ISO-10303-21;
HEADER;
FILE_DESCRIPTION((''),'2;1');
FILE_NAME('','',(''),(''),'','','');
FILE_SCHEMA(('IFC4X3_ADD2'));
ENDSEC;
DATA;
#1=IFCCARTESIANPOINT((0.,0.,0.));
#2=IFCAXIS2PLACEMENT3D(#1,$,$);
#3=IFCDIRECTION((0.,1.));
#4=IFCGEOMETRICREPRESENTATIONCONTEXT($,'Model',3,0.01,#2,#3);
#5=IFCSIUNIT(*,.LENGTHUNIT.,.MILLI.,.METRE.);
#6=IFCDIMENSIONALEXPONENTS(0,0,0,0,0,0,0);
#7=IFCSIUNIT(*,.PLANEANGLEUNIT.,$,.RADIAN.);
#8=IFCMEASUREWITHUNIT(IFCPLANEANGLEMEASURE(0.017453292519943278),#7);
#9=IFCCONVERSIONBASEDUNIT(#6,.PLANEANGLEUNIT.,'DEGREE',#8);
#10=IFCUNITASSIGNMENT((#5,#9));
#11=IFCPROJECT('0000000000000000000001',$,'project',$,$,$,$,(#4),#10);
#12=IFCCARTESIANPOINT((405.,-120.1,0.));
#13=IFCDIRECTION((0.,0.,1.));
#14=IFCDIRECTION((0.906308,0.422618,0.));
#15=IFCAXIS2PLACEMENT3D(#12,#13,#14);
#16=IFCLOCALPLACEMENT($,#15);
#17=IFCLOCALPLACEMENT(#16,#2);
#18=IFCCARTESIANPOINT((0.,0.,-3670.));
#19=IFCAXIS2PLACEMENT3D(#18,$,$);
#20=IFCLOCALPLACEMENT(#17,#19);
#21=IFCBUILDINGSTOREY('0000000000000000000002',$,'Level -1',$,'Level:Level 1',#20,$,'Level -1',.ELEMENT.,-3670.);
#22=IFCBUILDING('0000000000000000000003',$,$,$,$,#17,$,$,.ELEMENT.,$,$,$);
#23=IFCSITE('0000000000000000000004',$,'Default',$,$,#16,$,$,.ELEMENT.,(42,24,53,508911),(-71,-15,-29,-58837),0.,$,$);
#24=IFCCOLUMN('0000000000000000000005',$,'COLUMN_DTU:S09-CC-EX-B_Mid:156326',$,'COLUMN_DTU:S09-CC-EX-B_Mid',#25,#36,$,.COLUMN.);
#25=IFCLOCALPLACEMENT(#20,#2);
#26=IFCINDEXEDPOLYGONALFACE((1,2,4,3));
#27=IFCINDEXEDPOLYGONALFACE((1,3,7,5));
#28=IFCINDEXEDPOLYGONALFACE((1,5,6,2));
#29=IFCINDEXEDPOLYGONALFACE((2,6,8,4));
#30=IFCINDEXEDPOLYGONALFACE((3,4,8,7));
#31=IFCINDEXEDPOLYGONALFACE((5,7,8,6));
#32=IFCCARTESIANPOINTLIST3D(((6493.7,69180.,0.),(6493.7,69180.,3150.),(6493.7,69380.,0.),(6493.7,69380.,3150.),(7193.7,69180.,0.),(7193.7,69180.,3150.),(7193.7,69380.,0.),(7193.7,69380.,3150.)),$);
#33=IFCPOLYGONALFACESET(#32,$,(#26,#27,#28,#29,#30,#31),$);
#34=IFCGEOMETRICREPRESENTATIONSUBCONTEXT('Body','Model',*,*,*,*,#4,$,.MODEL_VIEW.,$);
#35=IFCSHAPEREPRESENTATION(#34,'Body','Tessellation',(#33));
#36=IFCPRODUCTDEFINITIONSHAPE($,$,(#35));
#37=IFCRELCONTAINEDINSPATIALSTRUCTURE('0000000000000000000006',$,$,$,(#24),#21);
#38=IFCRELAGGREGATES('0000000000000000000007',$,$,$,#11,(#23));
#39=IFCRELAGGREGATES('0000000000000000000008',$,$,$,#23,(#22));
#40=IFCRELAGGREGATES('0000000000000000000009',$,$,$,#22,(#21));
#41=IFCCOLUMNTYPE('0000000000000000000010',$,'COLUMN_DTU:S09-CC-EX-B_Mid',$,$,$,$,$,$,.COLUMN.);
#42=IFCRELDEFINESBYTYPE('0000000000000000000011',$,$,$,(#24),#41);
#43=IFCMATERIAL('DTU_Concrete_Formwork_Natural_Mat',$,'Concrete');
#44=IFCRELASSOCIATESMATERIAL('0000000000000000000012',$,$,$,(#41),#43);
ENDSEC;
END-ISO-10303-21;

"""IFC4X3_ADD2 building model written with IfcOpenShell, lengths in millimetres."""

from ifc_helpers import new_model, entity, si_unit, converted_unit, direction, frame, frame_2d, origin, place, context, subcontext, project, spatial, rectangle, extrude, source, transform, mapped, material, material_profile, profile_set, type_object, type_shapes, element, save


model = new_model("IFC4X3_ADD2")

# Units and contexts
model_context = context("Model", 3, precision=0.01, world=origin(), true_north=direction((0.0, 1.0)))
body_context = subcontext(model_context, "Body", "Model", "MODEL_VIEW")
ifc_project = project(units=[si_unit("LENGTHUNIT", "METRE", prefix="MILLI"), converted_unit("PLANEANGLEUNIT", "DEGREE", entity("IfcPlaneAngleMeasure", 0.017453292519943278), si_unit("PLANEANGLEUNIT", "RADIAN"), dimensions=[0, 0, 0, 0, 0, 0, 0])], contexts=[model_context])

# Site, building, storey
site_placement = place(None, frame((405.0, -120.1, 0.0), z_axis=(0.0, 0.0, 1.0), x_axis=(0.906308, 0.422618, 0.0)))
site = spatial("IfcSite", under=ifc_project, at=site_placement, Name="Default", CompositionType="ELEMENT", RefLatitude=(42, 24, 53, 508911), RefLongitude=(-71, -15, -29, -58837), RefElevation=0.0)
building_placement = place(site_placement, origin())
building = spatial("IfcBuilding", under=site, at=building_placement, CompositionType="ELEMENT")
storey_placement = place(building_placement, frame((0.0, 0.0, -3670.0)))
storey = spatial("IfcBuildingStorey", under=building, at=storey_placement, Name="Level -1", ObjectType="Level:Level 1", LongName="Level -1", CompositionType="ELEMENT", Elevation=-3670.0)

# Column
ifc_material = material(Name="DTU_Concrete_Formwork_Natural_Mat", Category="Concrete")
ifc_material_profile_1 = material_profile(ifc_material, rectangle(XDim=200.0, YDim=700.0, at=frame_2d((0.0, 0.0), x_axis=(1.0, 0.0))), Name="S09-CC-EX-B_Mid")
ifc_profile_set_1 = profile_set([ifc_material_profile_1], Name="S09-CC-EX-B_Mid")
column_type_1 = type_object("IfcColumnType", Name="COLUMN_DTU:S09-CC-EX-B_Mid", PredefinedType="COLUMN", material=ifc_profile_set_1)
shared_shape_1 = source(origin(), body_context, "Body", "SweptSolid", [
    extrude(rectangle(XDim=200.0, YDim=700.0, at=frame_2d((0.0, 0.0), x_axis=(1.0, 0.0))), frame((6843.7, 69280.0, -3670.0), z_axis=(0.0, 0.0, 1.0), x_axis=(0.0, 1.0, 0.0)), (0.0, 0.0, 1.0), 3150.0),
])
type_shapes(column_type_1, [shared_shape_1])
column_1_placement = place(storey_placement, frame((0.0, 0.0, 3670.0)))
element("IfcColumn", 1, at=column_1_placement, inside=storey, type_object=column_type_1, Name="COLUMN_DTU:S09-CC-EX-B_Mid:156326", ObjectType="COLUMN_DTU:S09-CC-EX-B_Mid", PredefinedType="COLUMN", context=body_context, shape_type="MappedRepresentation", body=[
    mapped(shared_shape_1, transform((0.0, 0.0, 0.0), scale=1.0)),
])

save(model, "model.ifc")
